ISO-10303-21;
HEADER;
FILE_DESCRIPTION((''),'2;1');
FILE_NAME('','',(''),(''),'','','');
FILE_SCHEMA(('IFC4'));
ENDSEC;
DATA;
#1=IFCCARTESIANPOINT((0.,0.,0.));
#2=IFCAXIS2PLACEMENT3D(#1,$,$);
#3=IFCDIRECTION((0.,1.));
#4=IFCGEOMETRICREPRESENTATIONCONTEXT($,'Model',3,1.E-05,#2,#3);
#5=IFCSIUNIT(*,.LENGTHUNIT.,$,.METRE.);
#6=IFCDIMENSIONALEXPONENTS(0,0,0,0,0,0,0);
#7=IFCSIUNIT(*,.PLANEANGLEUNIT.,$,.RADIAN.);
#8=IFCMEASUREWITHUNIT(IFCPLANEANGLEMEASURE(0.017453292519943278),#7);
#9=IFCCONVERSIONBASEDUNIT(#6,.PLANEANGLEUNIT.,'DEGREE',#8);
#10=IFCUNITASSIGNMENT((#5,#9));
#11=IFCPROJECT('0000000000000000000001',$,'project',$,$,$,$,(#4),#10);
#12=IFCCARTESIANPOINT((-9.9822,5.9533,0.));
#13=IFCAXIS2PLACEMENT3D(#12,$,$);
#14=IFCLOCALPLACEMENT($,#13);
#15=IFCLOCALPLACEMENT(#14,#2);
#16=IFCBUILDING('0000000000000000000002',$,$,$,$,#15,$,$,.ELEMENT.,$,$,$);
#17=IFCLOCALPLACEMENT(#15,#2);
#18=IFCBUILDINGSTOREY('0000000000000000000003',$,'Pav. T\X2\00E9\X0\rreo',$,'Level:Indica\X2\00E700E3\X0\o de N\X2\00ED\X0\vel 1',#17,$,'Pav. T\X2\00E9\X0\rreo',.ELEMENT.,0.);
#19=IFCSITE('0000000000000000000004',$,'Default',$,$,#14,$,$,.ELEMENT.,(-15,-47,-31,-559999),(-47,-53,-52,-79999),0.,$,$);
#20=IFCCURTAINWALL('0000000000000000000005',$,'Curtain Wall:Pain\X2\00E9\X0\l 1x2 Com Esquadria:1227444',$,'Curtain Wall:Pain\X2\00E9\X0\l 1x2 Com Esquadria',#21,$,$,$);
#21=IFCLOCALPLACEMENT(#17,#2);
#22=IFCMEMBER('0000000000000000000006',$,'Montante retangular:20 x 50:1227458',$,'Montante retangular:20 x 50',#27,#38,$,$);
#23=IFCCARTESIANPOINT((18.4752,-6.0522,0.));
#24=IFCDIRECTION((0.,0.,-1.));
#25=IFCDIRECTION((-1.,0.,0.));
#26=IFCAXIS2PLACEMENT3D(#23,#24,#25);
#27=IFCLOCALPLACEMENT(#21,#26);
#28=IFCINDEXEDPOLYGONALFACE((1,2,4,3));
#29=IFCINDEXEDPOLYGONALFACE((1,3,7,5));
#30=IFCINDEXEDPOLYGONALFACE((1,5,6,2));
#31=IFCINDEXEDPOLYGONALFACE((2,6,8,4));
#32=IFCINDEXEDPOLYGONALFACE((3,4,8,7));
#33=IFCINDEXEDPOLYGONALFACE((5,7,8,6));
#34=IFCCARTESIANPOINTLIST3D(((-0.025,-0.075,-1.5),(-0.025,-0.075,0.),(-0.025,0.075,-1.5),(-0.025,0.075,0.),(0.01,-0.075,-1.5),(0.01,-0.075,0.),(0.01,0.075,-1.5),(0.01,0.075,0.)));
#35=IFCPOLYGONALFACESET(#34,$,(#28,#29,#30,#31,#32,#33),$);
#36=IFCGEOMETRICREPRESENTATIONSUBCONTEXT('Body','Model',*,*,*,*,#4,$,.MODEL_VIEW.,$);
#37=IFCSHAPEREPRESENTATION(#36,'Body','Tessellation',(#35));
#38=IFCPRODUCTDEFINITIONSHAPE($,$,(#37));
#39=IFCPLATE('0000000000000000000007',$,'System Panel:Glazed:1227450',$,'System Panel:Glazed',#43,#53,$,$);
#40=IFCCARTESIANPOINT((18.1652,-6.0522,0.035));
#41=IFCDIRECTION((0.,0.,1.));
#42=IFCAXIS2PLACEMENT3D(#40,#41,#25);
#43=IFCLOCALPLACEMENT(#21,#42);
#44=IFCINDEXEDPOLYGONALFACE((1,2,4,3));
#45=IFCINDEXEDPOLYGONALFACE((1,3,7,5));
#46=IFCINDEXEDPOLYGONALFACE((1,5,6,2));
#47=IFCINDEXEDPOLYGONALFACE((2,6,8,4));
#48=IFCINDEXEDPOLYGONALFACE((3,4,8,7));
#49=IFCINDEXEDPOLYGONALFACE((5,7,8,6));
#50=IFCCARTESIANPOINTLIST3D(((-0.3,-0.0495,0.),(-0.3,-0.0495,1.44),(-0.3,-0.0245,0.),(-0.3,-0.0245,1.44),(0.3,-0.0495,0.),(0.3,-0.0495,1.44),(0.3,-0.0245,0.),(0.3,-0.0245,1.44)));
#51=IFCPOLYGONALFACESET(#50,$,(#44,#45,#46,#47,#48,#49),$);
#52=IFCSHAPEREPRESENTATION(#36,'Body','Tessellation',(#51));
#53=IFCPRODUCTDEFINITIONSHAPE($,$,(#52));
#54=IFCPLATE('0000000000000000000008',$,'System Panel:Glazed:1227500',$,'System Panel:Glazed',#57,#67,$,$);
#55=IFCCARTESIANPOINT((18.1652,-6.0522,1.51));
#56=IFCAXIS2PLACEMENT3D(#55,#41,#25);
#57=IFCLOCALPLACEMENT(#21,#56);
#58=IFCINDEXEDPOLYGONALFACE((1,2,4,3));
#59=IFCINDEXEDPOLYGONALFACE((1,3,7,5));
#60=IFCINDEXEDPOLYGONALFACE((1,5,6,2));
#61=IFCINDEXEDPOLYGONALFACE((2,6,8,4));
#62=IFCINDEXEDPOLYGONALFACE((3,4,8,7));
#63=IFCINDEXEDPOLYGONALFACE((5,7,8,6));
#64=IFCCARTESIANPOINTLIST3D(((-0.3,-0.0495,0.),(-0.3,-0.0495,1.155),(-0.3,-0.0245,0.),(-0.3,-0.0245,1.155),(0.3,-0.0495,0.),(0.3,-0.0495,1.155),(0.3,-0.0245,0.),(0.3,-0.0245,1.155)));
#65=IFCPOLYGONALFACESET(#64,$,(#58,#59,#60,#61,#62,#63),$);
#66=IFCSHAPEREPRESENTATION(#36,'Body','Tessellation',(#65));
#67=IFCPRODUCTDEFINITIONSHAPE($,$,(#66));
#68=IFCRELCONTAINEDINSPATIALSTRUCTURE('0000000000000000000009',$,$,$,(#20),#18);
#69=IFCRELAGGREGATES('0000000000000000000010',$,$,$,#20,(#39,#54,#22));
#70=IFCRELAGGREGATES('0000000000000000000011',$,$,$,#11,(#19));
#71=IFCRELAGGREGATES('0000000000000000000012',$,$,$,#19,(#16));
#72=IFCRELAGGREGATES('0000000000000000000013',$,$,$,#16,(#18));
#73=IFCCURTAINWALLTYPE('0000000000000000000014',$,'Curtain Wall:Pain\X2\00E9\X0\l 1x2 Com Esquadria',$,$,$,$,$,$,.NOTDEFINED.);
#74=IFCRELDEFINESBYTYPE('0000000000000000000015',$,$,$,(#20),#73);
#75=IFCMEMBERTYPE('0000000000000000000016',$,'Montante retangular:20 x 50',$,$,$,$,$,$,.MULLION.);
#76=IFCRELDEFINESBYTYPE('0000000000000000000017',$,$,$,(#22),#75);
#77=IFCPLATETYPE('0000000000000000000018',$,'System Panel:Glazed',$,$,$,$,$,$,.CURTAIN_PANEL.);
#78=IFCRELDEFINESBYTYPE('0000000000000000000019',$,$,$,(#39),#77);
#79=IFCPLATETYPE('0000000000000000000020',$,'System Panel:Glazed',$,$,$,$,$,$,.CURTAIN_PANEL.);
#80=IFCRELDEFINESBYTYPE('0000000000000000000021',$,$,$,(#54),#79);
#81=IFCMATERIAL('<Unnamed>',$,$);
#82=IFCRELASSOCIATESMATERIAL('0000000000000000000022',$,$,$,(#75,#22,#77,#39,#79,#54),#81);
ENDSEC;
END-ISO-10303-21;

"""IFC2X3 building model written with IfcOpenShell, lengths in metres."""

from ifc_helpers import new_model, entity, si_unit, converted_unit, direction, frame, frame_2d, origin, origin_2d_with_axis, place, context, subcontext, project, spatial, rectangle, extrude, source, transform, mapped, material, type_object, type_shapes, element, aggregate, save


model = new_model("IFC2X3")

# Units and contexts
model_context = context("Model", 3, precision=1e-05, world=origin(), true_north=direction((0.0, 1.0)))
body_context = subcontext(model_context, "Body", "Model", "MODEL_VIEW")
ifc_project = project(units=[si_unit("LENGTHUNIT", "METRE"), converted_unit("PLANEANGLEUNIT", "DEGREE", entity("IfcPlaneAngleMeasure", 0.017453292519943278), si_unit("PLANEANGLEUNIT", "RADIAN"), dimensions=[0, 0, 0, 0, 0, 0, 0])], contexts=[model_context])

# Site, building, storey
site_placement = place(None, frame((-9.9822, 5.9533, 0.0)))
site = spatial("IfcSite", under=ifc_project, at=site_placement, Name="Default", CompositionType="ELEMENT", RefLatitude=(-15, -47, -31, -559999), RefLongitude=(-47, -53, -52, -79999), RefElevation=0.0)
building_placement = place(site_placement, origin())
building = spatial("IfcBuilding", under=site, at=building_placement, CompositionType="ELEMENT")
storey_placement = place(building_placement, origin())
storey = spatial("IfcBuildingStorey", under=building, at=storey_placement, Name="Pav. Térreo", ObjectType="Level:Indicação de Nível 1", LongName="Pav. Térreo", CompositionType="ELEMENT", Elevation=0.0)

# Curtain wall, member, plates
curtain_wall_type = type_object("IfcCurtainWallType", Name="Curtain Wall:Painél 1x2 Com Esquadria", PredefinedType="NOTDEFINED")
curtain_wall_placement = place(storey_placement, origin())
curtain_wall = element("IfcCurtainWall", 1, at=curtain_wall_placement, inside=storey, type_object=curtain_wall_type, Name="Curtain Wall:Painél 1x2 Com Esquadria:1227444", ObjectType="Curtain Wall:Painél 1x2 Com Esquadria")
ifc_material_1 = material(Name="<Unnamed>")
member_type_1 = type_object("IfcMemberType", Name="Montante retangular:20 x 50", PredefinedType="MULLION", material=ifc_material_1)
shared_shape_1 = source(origin(), body_context, "Body", "SweptSolid", [
    extrude(rectangle(XDim=0.035, YDim=0.15, at=origin_2d_with_axis()), frame((-0.0075, 0.0, -1.5), z_axis=(0.0, 0.0, 1.0), x_axis=(-1.0, 0.0, 0.0)), (0.0, 0.0, 1.0), 1.5),
])
type_shapes(member_type_1, [shared_shape_1])
member_1_placement = place(curtain_wall_placement, frame((18.4752, -6.0522, 0.0), z_axis=(0.0, 0.0, -1.0), x_axis=(-1.0, 0.0, 0.0)))
member_1 = element("IfcMember", 2, at=member_1_placement, type_object=member_type_1, material=ifc_material_1, Name="Montante retangular:20 x 50:1227458", ObjectType="Montante retangular:20 x 50", context=body_context, shape_type="MappedRepresentation", body=[
    mapped(shared_shape_1, transform((0.0, 0.0, 0.0), scale=1.0)),
])
plate_type_1 = type_object("IfcPlateType", Name="System Panel:Glazed", PredefinedType="CURTAIN_PANEL", material=ifc_material_1)
shared_shape_2 = source(origin(), body_context, "Body", "SweptSolid", [
    extrude(rectangle(XDim=0.025, YDim=0.6, at=frame_2d((0.0, 0.0), x_axis=(1.0, 0.0))), frame((0.0, -0.037, 0.0), z_axis=(0.0, 0.0, 1.0), x_axis=(0.0, 1.0, 0.0)), (0.0, 0.0, 1.0), 1.44),
])
type_shapes(plate_type_1, [shared_shape_2])
plate_1_placement = place(curtain_wall_placement, frame((18.1652, -6.0522, 0.035), z_axis=(0.0, 0.0, 1.0), x_axis=(-1.0, 0.0, 0.0)))
plate_1 = element("IfcPlate", 3, at=plate_1_placement, type_object=plate_type_1, material=ifc_material_1, Name="System Panel:Glazed:1227450", ObjectType="System Panel:Glazed", context=body_context, shape_type="MappedRepresentation", body=[
    mapped(shared_shape_2, transform((0.0, 0.0, 0.0), scale=1.0)),
])
plate_type_2 = type_object("IfcPlateType", Name="System Panel:Glazed", PredefinedType="CURTAIN_PANEL", material=ifc_material_1)
shared_shape_3 = source(origin(), body_context, "Body", "SweptSolid", [
    extrude(rectangle(XDim=0.025, YDim=0.6, at=frame_2d((0.0, 0.0), x_axis=(1.0, 0.0))), frame((0.0, -0.037, 0.0), z_axis=(0.0, 0.0, 1.0), x_axis=(0.0, 1.0, 0.0)), (0.0, 0.0, 1.0), 1.155),
])
type_shapes(plate_type_2, [shared_shape_3])
plate_2_placement = place(curtain_wall_placement, frame((18.1652, -6.0522, 1.51), z_axis=(0.0, 0.0, 1.0), x_axis=(-1.0, 0.0, 0.0)))
plate_2 = element("IfcPlate", 4, at=plate_2_placement, type_object=plate_type_2, material=ifc_material_1, Name="System Panel:Glazed:1227500", ObjectType="System Panel:Glazed", context=body_context, shape_type="MappedRepresentation", body=[
    mapped(shared_shape_3, transform((0.0, 0.0, 0.0), scale=1.0)),
])
aggregate(curtain_wall, [plate_1, plate_2, member_1])

save(model, "model.ifc")
